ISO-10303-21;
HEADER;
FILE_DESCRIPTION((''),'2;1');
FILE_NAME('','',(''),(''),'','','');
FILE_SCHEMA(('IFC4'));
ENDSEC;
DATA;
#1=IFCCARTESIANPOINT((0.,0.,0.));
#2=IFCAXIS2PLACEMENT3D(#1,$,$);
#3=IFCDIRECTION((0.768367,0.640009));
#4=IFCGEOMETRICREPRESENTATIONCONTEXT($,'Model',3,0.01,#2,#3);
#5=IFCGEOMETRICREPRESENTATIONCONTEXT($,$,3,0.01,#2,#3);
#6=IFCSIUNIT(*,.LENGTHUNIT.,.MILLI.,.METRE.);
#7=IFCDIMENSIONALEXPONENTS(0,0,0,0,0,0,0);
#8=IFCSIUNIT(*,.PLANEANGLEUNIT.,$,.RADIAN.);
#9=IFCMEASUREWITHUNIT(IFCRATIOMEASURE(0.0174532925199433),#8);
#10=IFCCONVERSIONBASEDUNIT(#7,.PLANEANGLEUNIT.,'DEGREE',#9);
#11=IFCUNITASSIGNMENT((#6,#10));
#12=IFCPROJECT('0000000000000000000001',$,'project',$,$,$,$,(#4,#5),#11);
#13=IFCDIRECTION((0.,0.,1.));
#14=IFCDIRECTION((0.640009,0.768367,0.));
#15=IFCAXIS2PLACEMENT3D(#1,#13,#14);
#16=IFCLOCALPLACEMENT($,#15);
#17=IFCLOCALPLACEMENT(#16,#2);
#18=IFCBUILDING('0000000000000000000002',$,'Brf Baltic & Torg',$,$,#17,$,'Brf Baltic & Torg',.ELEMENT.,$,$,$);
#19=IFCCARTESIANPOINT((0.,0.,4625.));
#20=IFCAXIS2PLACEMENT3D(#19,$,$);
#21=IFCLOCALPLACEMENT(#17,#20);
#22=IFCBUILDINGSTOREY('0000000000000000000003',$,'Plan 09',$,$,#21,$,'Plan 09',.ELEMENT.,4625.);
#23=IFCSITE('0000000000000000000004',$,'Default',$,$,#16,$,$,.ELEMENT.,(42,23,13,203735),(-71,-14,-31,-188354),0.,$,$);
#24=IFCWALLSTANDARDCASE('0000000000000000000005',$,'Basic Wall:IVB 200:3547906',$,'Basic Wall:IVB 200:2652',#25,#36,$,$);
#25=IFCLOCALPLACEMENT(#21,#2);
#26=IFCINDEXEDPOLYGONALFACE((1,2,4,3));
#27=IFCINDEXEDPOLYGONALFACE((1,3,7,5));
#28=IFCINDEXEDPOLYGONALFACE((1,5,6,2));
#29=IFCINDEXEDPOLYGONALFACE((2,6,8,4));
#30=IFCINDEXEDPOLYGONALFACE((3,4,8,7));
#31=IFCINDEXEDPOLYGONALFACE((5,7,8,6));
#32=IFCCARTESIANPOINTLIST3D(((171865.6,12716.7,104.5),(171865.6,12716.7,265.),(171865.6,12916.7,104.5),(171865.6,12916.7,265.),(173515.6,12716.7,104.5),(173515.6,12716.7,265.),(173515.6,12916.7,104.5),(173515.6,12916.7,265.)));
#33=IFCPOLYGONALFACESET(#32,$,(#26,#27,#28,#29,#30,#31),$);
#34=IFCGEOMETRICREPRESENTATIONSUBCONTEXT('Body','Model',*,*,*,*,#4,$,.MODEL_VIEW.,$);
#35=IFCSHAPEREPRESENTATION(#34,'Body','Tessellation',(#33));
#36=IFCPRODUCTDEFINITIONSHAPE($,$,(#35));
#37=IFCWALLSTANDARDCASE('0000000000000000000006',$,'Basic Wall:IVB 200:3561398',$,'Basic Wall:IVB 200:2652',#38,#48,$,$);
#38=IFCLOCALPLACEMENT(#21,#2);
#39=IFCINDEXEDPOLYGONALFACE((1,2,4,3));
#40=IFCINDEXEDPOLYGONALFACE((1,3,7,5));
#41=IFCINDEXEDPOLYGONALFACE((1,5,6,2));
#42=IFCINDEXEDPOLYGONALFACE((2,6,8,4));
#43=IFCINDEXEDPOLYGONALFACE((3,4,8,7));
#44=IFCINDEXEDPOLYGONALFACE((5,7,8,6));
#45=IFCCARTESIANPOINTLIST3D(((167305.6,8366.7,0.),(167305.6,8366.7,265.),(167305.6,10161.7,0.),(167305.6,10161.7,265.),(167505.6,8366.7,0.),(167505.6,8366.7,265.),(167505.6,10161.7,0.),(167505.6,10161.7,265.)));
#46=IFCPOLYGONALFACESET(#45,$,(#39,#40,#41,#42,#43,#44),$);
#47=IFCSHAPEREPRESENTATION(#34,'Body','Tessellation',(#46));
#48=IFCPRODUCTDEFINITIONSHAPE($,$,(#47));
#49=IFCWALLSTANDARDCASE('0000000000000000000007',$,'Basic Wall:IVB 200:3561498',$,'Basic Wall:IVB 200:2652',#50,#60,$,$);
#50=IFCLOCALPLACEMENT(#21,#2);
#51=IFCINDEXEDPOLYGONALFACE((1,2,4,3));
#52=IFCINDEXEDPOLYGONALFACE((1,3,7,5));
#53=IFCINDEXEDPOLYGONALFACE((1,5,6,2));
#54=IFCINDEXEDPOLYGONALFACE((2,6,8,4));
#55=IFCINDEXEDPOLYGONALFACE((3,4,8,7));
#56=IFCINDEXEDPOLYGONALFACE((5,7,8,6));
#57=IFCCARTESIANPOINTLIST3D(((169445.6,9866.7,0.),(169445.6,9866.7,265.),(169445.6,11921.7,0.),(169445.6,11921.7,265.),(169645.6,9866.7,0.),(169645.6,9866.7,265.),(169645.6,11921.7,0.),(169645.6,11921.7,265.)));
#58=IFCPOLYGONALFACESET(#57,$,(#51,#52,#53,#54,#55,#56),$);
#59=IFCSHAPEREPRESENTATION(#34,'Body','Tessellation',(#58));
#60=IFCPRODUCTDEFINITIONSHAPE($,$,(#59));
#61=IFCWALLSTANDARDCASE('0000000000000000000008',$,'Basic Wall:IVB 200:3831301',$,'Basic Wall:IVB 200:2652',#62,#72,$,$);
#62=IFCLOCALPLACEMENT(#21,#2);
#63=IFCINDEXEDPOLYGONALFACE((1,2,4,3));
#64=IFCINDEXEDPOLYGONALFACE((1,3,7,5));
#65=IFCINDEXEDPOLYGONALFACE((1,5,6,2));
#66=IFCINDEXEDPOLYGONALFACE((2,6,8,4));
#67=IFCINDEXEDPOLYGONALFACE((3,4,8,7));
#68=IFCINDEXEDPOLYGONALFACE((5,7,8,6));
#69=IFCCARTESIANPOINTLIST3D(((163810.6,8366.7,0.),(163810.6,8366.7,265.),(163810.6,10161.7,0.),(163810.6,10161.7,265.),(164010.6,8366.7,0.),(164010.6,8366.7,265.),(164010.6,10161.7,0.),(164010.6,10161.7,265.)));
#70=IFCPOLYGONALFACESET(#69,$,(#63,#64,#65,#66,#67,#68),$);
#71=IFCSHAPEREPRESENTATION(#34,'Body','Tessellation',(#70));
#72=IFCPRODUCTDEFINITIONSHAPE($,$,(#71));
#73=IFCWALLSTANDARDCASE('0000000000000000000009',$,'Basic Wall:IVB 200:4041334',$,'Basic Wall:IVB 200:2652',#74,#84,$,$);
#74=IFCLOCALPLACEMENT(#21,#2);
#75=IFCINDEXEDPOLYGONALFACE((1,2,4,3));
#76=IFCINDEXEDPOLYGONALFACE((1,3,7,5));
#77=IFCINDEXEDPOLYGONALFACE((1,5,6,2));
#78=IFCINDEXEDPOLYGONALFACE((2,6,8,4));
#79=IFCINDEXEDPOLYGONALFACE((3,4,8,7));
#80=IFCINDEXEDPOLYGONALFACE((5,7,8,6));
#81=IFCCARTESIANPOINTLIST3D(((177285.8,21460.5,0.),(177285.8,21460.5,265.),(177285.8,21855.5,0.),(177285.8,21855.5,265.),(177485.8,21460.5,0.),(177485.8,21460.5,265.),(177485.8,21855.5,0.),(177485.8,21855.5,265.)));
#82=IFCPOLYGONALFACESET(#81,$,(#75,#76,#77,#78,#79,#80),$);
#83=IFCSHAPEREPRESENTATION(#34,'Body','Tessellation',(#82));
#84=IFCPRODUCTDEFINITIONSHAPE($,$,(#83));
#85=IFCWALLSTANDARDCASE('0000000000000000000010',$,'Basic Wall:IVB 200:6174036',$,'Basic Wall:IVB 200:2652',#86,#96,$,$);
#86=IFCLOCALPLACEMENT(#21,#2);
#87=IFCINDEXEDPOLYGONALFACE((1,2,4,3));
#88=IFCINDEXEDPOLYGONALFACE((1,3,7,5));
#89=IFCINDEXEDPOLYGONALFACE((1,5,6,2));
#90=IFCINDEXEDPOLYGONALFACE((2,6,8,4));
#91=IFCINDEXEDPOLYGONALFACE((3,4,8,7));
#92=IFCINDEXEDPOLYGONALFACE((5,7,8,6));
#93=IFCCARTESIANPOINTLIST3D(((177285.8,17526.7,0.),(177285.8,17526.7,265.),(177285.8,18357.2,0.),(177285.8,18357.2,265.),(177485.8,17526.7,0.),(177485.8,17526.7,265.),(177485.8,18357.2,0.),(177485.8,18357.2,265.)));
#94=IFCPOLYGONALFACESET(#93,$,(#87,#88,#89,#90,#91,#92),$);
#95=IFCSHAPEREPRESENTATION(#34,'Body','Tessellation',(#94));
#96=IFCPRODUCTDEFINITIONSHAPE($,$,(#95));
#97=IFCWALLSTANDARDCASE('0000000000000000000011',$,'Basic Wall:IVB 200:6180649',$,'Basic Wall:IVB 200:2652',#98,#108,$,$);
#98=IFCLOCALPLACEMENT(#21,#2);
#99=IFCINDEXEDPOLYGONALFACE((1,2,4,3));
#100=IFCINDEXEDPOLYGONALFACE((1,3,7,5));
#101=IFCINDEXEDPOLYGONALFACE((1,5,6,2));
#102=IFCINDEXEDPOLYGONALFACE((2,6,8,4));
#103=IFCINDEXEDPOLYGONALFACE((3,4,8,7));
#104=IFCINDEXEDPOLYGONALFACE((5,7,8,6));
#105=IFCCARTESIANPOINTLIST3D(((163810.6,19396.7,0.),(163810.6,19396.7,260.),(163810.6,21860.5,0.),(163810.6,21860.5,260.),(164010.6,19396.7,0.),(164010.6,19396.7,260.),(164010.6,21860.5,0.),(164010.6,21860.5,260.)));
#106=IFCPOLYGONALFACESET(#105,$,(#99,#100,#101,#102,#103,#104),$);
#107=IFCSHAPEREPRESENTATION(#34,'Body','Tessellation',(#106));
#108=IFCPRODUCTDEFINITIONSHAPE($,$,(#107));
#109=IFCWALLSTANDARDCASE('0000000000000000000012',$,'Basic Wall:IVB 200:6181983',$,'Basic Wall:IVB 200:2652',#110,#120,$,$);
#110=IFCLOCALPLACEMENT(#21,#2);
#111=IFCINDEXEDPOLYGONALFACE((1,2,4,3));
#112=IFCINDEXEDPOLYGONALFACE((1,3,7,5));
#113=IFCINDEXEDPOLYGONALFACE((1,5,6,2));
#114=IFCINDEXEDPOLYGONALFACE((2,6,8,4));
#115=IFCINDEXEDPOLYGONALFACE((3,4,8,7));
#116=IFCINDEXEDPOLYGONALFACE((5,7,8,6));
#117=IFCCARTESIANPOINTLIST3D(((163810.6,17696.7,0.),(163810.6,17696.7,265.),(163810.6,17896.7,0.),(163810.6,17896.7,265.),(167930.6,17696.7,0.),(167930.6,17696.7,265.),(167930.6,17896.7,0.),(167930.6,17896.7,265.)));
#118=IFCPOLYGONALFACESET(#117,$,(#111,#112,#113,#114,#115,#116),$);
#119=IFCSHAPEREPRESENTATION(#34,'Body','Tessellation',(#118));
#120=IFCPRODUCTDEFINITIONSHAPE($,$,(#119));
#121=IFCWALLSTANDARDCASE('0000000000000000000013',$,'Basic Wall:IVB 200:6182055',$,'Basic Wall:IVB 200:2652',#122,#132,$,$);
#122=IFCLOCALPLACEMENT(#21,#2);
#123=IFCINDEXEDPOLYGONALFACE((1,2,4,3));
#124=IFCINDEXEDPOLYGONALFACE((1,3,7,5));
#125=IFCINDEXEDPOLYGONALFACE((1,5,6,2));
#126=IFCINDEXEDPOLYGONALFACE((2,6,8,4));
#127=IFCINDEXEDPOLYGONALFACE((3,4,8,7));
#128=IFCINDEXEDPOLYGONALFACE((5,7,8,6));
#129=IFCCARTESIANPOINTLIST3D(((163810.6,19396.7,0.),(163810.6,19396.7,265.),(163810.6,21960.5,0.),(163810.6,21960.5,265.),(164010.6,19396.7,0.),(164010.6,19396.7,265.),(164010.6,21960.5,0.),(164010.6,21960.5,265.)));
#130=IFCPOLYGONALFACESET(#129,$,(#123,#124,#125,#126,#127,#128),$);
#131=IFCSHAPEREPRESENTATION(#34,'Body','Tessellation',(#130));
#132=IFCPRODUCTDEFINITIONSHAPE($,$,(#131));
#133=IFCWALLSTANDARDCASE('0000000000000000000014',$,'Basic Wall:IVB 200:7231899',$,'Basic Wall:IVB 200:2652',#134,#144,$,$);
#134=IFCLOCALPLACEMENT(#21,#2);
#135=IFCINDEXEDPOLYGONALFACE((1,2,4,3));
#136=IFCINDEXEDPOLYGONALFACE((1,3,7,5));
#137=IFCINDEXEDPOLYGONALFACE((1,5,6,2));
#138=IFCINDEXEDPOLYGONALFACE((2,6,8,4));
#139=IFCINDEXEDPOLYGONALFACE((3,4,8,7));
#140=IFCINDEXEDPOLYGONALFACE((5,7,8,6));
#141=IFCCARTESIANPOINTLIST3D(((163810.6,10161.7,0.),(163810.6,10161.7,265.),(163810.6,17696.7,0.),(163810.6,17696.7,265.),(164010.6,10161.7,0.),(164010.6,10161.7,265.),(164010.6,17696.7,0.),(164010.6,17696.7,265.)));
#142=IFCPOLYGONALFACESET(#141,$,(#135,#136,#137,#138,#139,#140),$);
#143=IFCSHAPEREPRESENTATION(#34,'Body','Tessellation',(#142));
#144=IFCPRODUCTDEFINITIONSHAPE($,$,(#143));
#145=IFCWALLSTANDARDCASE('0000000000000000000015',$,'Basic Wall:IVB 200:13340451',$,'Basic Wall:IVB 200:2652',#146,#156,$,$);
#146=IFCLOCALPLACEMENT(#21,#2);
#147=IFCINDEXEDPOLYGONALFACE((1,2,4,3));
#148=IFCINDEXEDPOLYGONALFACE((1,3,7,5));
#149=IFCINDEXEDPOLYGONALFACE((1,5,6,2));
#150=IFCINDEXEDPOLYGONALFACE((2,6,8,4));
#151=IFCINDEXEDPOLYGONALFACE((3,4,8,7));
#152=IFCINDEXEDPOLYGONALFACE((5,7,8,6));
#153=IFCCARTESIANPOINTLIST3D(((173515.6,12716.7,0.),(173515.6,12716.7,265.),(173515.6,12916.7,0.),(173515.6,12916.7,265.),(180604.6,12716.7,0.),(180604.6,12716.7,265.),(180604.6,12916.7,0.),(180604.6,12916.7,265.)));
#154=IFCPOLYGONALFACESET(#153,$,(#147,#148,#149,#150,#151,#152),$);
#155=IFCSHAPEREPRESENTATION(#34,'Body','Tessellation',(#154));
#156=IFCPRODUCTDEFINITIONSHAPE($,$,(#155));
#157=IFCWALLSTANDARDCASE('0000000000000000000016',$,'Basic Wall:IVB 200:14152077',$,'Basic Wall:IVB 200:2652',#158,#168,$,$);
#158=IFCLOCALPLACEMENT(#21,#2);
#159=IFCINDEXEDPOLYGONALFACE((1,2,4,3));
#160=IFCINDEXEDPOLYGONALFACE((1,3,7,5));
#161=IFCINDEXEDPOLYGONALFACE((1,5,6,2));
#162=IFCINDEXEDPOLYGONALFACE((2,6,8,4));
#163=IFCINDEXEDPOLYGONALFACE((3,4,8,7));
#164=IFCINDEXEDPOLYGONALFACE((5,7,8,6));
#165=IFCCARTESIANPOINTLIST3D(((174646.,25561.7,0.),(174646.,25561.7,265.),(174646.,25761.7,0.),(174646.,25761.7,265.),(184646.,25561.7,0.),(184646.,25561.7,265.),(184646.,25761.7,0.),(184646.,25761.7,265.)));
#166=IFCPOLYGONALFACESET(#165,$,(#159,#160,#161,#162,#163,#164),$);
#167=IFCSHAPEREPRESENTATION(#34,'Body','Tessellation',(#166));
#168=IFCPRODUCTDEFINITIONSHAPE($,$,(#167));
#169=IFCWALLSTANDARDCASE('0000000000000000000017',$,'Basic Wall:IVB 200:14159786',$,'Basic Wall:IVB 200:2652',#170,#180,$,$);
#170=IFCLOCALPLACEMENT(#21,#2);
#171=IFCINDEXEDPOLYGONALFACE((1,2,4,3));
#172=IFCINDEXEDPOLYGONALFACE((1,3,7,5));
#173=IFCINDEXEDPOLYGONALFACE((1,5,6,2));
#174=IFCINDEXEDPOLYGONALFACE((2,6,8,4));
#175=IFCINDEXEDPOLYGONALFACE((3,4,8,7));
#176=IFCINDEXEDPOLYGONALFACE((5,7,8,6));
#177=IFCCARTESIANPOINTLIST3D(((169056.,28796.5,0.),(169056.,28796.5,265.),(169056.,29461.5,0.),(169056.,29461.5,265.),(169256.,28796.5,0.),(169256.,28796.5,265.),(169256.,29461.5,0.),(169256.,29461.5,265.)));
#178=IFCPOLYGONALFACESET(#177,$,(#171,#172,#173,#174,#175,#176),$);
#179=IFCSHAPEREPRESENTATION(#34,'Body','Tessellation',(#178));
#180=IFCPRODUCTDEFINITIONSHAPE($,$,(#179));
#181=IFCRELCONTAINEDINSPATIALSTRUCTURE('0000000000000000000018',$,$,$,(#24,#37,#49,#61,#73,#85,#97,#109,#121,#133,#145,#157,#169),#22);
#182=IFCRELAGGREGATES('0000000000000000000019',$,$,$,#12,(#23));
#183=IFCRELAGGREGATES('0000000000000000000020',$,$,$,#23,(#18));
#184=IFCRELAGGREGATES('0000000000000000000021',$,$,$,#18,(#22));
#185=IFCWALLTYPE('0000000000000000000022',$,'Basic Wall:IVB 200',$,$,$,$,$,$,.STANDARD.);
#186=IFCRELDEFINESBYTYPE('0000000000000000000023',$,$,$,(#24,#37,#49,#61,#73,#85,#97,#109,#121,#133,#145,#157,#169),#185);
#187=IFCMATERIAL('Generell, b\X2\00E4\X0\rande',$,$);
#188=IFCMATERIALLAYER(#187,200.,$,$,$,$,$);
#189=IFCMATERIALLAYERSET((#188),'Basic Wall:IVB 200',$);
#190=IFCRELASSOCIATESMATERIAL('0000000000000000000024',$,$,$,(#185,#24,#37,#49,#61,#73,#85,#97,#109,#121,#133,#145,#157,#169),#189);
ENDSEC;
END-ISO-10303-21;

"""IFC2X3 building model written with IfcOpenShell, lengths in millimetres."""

from ifc_helpers import new_model, entity, si_unit, converted_unit, direction, frame, frame_2d, origin, place, context, subcontext, project, spatial, rectangle, extrude, clip, halfspace, material, layer, layer_set, layer_usage, type_object, element, save


model = new_model("IFC2X3")

# Units and contexts
model_context = context("Model", 3, precision=0.01, world=origin(), true_north=direction((0.768367, 0.640009)))
context_of_model = context(None, 3, precision=0.01, world=origin(), true_north=direction((0.768367, 0.640009)))
body_context = subcontext(model_context, "Body", "Model", "MODEL_VIEW")
ifc_project = project(units=[si_unit("LENGTHUNIT", "METRE", prefix="MILLI"), converted_unit("PLANEANGLEUNIT", "DEGREE", entity("IfcRatioMeasure", 0.0174532925199433), si_unit("PLANEANGLEUNIT", "RADIAN"), dimensions=[0, 0, 0, 0, 0, 0, 0])], contexts=[model_context, context_of_model])

# Site, building, storey
site_placement = place(None, frame((0.0, 0.0, 0.0), z_axis=(0.0, 0.0, 1.0), x_axis=(0.640009, 0.768367, 0.0)))
site = spatial("IfcSite", under=ifc_project, at=site_placement, Name="Default", CompositionType="ELEMENT", RefLatitude=(42, 23, 13, 203735), RefLongitude=(-71, -14, -31, -188354), RefElevation=0.0)
building_placement = place(site_placement, origin())
building = spatial("IfcBuilding", under=site, at=building_placement, Name="Brf Baltic & Torg", LongName="Brf Baltic & Torg", CompositionType="ELEMENT")
storey_placement = place(building_placement, frame((0.0, 0.0, 4625.0)))
storey = spatial("IfcBuildingStorey", under=building, at=storey_placement, Name="Plan 09", LongName="Plan 09", CompositionType="ELEMENT", Elevation=4625.0)

# Shared definitions
ifc_material_1 = material(Name="Generell, bärande")
ifc_layer = layer(ifc_material_1, 200.0)
ifc_layer_set = layer_set([ifc_layer], Name="Basic Wall:IVB 200")
wall_type = type_object("IfcWallType", Name="Basic Wall:IVB 200", PredefinedType="STANDARD", material=ifc_layer_set)

# Walls
ifc_layer_usage_1 = layer_usage(ifc_layer_set, "AXIS2", "NEGATIVE", 100.0)
wall_1_placement = place(storey_placement, frame((171865.6, 12816.7, 104.5)))
element("IfcWallStandardCase", 1, at=wall_1_placement, inside=storey, type_object=wall_type, material=ifc_layer_usage_1, Name="Basic Wall:IVB 200:3547906", ObjectType="Basic Wall:IVB 200:2652", context=body_context, shape_type="Clipping", body=[
    clip(extrude(rectangle(XDim=1650.0, YDim=200.0, at=frame_2d((825.0, 0.0), x_axis=(-1.0, 0.0))), origin(), (0.0, 0.0, 1.0), 160.5), halfspace(origin(), True)),
])
ifc_layer_usage_2 = layer_usage(ifc_layer_set, "AXIS2", "NEGATIVE", 100.0)
wall_2_placement = place(storey_placement, frame((167405.6, 10161.7, 0.0), z_axis=(0.0, 0.0, 1.0), x_axis=(0.0, -1.0, 0.0)))
element("IfcWallStandardCase", 2, at=wall_2_placement, inside=storey, type_object=wall_type, material=ifc_layer_usage_2, Name="Basic Wall:IVB 200:3561398", ObjectType="Basic Wall:IVB 200:2652", context=body_context, shape_type="Clipping", body=[
    clip(extrude(rectangle(XDim=1795.0, YDim=200.0, at=frame_2d((897.5, 0.0), x_axis=(-1.0, 0.0))), origin(), (0.0, 0.0, 1.0), 265.0), halfspace(origin(), True)),
])

# Walls
ifc_layer_usage_3 = layer_usage(ifc_layer_set, "AXIS2", "POSITIVE", -100.0)
wall_3_placement = place(storey_placement, frame((169545.6, 11921.7, 0.0), z_axis=(0.0, 0.0, 1.0), x_axis=(0.0, -1.0, 0.0)))
element("IfcWallStandardCase", 3, at=wall_3_placement, inside=storey, type_object=wall_type, material=ifc_layer_usage_3, Name="Basic Wall:IVB 200:3561498", ObjectType="Basic Wall:IVB 200:2652", context=body_context, shape_type="Clipping", body=[
    clip(extrude(rectangle(XDim=2055.0, YDim=200.0, at=frame_2d((1027.5, 0.0), x_axis=(-1.0, 0.0))), origin(), (0.0, 0.0, 1.0), 265.0), halfspace(origin(), True)),
])
ifc_layer_usage_4 = layer_usage(ifc_layer_set, "AXIS2", "NEGATIVE", 100.0)
wall_4_placement = place(storey_placement, frame((163910.6, 8366.7, 0.0), z_axis=(0.0, 0.0, 1.0), x_axis=(0.0, 1.0, 0.0)))
element("IfcWallStandardCase", 4, at=wall_4_placement, inside=storey, type_object=wall_type, material=ifc_layer_usage_4, Name="Basic Wall:IVB 200:3831301", ObjectType="Basic Wall:IVB 200:2652", context=body_context, shape_type="Clipping", body=[
    clip(extrude(rectangle(XDim=1795.0, YDim=200.0, at=frame_2d((897.5, 0.0), x_axis=(-1.0, 0.0))), origin(), (0.0, 0.0, 1.0), 265.0), halfspace(origin(), True)),
])
ifc_layer_usage_5 = layer_usage(ifc_layer_set, "AXIS2", "NEGATIVE", 100.0)
wall_5_placement = place(storey_placement, frame((177385.8, 21460.5, 0.0), z_axis=(0.0, 0.0, 1.0), x_axis=(0.0, 1.0, 0.0)))
element("IfcWallStandardCase", 5, at=wall_5_placement, inside=storey, type_object=wall_type, material=ifc_layer_usage_5, Name="Basic Wall:IVB 200:4041334", ObjectType="Basic Wall:IVB 200:2652", context=body_context, shape_type="Clipping", body=[
    clip(extrude(rectangle(XDim=395.0, YDim=200.0, at=frame_2d((197.5, 0.0), x_axis=(-1.0, 0.0))), origin(), (0.0, 0.0, 1.0), 265.0), halfspace(origin(), True)),
])
ifc_layer_usage_6 = layer_usage(ifc_layer_set, "AXIS2", "NEGATIVE", 100.0)
wall_6_placement = place(storey_placement, frame((177385.8, 17526.7, 0.0), z_axis=(0.0, 0.0, 1.0), x_axis=(0.0, 1.0, 0.0)))
element("IfcWallStandardCase", 6, at=wall_6_placement, inside=storey, type_object=wall_type, material=ifc_layer_usage_6, Name="Basic Wall:IVB 200:6174036", ObjectType="Basic Wall:IVB 200:2652", context=body_context, shape_type="Clipping", body=[
    clip(extrude(rectangle(XDim=830.5, YDim=200.0, at=frame_2d((415.2, 0.0), x_axis=(-1.0, 0.0))), origin(), (0.0, 0.0, 1.0), 265.0), halfspace(origin(), True)),
])
ifc_layer_usage_7 = layer_usage(ifc_layer_set, "AXIS2", "NEGATIVE", 100.0)
wall_7_placement = place(storey_placement, frame((163910.6, 19396.7, 0.0), z_axis=(0.0, 0.0, 1.0), x_axis=(0.0, 1.0, 0.0)))
element("IfcWallStandardCase", 7, at=wall_7_placement, inside=storey, type_object=wall_type, material=ifc_layer_usage_7, Name="Basic Wall:IVB 200:6180649", ObjectType="Basic Wall:IVB 200:2652", context=body_context, shape_type="Clipping", body=[
    clip(extrude(rectangle(XDim=2463.7, YDim=200.0, at=frame_2d((1231.9, 0.0), x_axis=(-1.0, 0.0))), origin(), (0.0, 0.0, 1.0), 260.0), halfspace(frame((0.0, 0.0, -2975.0)), True)),
])
ifc_layer_usage_8 = layer_usage(ifc_layer_set, "AXIS2", "POSITIVE", -100.0)
wall_8_placement = place(storey_placement, frame((167930.6, 17796.7, 0.0), z_axis=(0.0, 0.0, 1.0), x_axis=(-1.0, 0.0, 0.0)))
element("IfcWallStandardCase", 8, at=wall_8_placement, inside=storey, type_object=wall_type, material=ifc_layer_usage_8, Name="Basic Wall:IVB 200:6181983", ObjectType="Basic Wall:IVB 200:2652", context=body_context, shape_type="Clipping", body=[
    clip(extrude(rectangle(XDim=4120.0, YDim=200.0, at=frame_2d((2060.0, 0.0), x_axis=(-1.0, 0.0))), origin(), (0.0, 0.0, 1.0), 265.0), halfspace(origin(), True)),
])
ifc_layer_usage_9 = layer_usage(ifc_layer_set, "AXIS2", "NEGATIVE", 100.0)
wall_9_placement = place(storey_placement, frame((163910.6, 19396.7, 0.0), z_axis=(0.0, 0.0, 1.0), x_axis=(0.0, 1.0, 0.0)))
element("IfcWallStandardCase", 9, at=wall_9_placement, inside=storey, type_object=wall_type, material=ifc_layer_usage_9, Name="Basic Wall:IVB 200:6182055", ObjectType="Basic Wall:IVB 200:2652", context=body_context, shape_type="Clipping", body=[
    clip(extrude(rectangle(XDim=2563.7, YDim=200.0, at=frame_2d((1281.9, 0.0), x_axis=(-1.0, 0.0))), origin(), (0.0, 0.0, 1.0), 265.0), halfspace(origin(), True)),
])
ifc_layer_usage_10 = layer_usage(ifc_layer_set, "AXIS2", "NEGATIVE", 100.0)
wall_10_placement = place(storey_placement, frame((163910.6, 10161.7, 0.0), z_axis=(0.0, 0.0, 1.0), x_axis=(0.0, 1.0, 0.0)))
element("IfcWallStandardCase", 10, at=wall_10_placement, inside=storey, type_object=wall_type, material=ifc_layer_usage_10, Name="Basic Wall:IVB 200:7231899", ObjectType="Basic Wall:IVB 200:2652", context=body_context, shape_type="Clipping", body=[
    clip(extrude(rectangle(XDim=7535.0, YDim=200.0, at=frame_2d((3767.5, 0.0), x_axis=(-1.0, 0.0))), origin(), (0.0, 0.0, 1.0), 265.0), halfspace(origin(), True)),
])
ifc_layer_usage_11 = layer_usage(ifc_layer_set, "AXIS2", "NEGATIVE", 100.0)
wall_11_placement = place(storey_placement, frame((173515.6, 12816.7, 0.0)))
element("IfcWallStandardCase", 11, at=wall_11_placement, inside=storey, type_object=wall_type, material=ifc_layer_usage_11, Name="Basic Wall:IVB 200:13340451", ObjectType="Basic Wall:IVB 200:2652", context=body_context, shape_type="Clipping", body=[
    clip(extrude(rectangle(XDim=7089.0, YDim=200.0, at=frame_2d((3544.5, 0.0), x_axis=(-1.0, 0.0))), origin(), (0.0, 0.0, 1.0), 265.0), halfspace(origin(), True)),
])

# Walls
ifc_layer_usage_12 = layer_usage(ifc_layer_set, "AXIS2", "NEGATIVE", 100.0)
wall_12_placement = place(storey_placement, frame((174646.0, 25661.7, 0.0)))
element("IfcWallStandardCase", 12, at=wall_12_placement, inside=storey, type_object=wall_type, material=ifc_layer_usage_12, Name="Basic Wall:IVB 200:14152077", ObjectType="Basic Wall:IVB 200:2652", context=body_context, shape_type="Clipping", body=[
    clip(extrude(rectangle(XDim=10000.0, YDim=200.0, at=frame_2d((5000.0, 0.0), x_axis=(-1.0, 0.0))), origin(), (0.0, 0.0, 1.0), 265.0), halfspace(frame((0.0, 0.0, -2975.0)), True)),
])
ifc_layer_usage_13 = layer_usage(ifc_layer_set, "AXIS2", "POSITIVE", -100.0)
wall_13_placement = place(storey_placement, frame((169156.0, 29461.5, 0.0), z_axis=(0.0, 0.0, 1.0), x_axis=(0.0, -1.0, 0.0)))
element("IfcWallStandardCase", 13, at=wall_13_placement, inside=storey, type_object=wall_type, material=ifc_layer_usage_13, Name="Basic Wall:IVB 200:14159786", ObjectType="Basic Wall:IVB 200:2652", context=body_context, shape_type="Clipping", body=[
    clip(extrude(rectangle(XDim=665.0, YDim=200.0, at=frame_2d((332.5, 0.0), x_axis=(-1.0, 0.0))), origin(), (0.0, 0.0, 1.0), 265.0), halfspace(origin(), True)),
])

save(model, "model.ifc")
